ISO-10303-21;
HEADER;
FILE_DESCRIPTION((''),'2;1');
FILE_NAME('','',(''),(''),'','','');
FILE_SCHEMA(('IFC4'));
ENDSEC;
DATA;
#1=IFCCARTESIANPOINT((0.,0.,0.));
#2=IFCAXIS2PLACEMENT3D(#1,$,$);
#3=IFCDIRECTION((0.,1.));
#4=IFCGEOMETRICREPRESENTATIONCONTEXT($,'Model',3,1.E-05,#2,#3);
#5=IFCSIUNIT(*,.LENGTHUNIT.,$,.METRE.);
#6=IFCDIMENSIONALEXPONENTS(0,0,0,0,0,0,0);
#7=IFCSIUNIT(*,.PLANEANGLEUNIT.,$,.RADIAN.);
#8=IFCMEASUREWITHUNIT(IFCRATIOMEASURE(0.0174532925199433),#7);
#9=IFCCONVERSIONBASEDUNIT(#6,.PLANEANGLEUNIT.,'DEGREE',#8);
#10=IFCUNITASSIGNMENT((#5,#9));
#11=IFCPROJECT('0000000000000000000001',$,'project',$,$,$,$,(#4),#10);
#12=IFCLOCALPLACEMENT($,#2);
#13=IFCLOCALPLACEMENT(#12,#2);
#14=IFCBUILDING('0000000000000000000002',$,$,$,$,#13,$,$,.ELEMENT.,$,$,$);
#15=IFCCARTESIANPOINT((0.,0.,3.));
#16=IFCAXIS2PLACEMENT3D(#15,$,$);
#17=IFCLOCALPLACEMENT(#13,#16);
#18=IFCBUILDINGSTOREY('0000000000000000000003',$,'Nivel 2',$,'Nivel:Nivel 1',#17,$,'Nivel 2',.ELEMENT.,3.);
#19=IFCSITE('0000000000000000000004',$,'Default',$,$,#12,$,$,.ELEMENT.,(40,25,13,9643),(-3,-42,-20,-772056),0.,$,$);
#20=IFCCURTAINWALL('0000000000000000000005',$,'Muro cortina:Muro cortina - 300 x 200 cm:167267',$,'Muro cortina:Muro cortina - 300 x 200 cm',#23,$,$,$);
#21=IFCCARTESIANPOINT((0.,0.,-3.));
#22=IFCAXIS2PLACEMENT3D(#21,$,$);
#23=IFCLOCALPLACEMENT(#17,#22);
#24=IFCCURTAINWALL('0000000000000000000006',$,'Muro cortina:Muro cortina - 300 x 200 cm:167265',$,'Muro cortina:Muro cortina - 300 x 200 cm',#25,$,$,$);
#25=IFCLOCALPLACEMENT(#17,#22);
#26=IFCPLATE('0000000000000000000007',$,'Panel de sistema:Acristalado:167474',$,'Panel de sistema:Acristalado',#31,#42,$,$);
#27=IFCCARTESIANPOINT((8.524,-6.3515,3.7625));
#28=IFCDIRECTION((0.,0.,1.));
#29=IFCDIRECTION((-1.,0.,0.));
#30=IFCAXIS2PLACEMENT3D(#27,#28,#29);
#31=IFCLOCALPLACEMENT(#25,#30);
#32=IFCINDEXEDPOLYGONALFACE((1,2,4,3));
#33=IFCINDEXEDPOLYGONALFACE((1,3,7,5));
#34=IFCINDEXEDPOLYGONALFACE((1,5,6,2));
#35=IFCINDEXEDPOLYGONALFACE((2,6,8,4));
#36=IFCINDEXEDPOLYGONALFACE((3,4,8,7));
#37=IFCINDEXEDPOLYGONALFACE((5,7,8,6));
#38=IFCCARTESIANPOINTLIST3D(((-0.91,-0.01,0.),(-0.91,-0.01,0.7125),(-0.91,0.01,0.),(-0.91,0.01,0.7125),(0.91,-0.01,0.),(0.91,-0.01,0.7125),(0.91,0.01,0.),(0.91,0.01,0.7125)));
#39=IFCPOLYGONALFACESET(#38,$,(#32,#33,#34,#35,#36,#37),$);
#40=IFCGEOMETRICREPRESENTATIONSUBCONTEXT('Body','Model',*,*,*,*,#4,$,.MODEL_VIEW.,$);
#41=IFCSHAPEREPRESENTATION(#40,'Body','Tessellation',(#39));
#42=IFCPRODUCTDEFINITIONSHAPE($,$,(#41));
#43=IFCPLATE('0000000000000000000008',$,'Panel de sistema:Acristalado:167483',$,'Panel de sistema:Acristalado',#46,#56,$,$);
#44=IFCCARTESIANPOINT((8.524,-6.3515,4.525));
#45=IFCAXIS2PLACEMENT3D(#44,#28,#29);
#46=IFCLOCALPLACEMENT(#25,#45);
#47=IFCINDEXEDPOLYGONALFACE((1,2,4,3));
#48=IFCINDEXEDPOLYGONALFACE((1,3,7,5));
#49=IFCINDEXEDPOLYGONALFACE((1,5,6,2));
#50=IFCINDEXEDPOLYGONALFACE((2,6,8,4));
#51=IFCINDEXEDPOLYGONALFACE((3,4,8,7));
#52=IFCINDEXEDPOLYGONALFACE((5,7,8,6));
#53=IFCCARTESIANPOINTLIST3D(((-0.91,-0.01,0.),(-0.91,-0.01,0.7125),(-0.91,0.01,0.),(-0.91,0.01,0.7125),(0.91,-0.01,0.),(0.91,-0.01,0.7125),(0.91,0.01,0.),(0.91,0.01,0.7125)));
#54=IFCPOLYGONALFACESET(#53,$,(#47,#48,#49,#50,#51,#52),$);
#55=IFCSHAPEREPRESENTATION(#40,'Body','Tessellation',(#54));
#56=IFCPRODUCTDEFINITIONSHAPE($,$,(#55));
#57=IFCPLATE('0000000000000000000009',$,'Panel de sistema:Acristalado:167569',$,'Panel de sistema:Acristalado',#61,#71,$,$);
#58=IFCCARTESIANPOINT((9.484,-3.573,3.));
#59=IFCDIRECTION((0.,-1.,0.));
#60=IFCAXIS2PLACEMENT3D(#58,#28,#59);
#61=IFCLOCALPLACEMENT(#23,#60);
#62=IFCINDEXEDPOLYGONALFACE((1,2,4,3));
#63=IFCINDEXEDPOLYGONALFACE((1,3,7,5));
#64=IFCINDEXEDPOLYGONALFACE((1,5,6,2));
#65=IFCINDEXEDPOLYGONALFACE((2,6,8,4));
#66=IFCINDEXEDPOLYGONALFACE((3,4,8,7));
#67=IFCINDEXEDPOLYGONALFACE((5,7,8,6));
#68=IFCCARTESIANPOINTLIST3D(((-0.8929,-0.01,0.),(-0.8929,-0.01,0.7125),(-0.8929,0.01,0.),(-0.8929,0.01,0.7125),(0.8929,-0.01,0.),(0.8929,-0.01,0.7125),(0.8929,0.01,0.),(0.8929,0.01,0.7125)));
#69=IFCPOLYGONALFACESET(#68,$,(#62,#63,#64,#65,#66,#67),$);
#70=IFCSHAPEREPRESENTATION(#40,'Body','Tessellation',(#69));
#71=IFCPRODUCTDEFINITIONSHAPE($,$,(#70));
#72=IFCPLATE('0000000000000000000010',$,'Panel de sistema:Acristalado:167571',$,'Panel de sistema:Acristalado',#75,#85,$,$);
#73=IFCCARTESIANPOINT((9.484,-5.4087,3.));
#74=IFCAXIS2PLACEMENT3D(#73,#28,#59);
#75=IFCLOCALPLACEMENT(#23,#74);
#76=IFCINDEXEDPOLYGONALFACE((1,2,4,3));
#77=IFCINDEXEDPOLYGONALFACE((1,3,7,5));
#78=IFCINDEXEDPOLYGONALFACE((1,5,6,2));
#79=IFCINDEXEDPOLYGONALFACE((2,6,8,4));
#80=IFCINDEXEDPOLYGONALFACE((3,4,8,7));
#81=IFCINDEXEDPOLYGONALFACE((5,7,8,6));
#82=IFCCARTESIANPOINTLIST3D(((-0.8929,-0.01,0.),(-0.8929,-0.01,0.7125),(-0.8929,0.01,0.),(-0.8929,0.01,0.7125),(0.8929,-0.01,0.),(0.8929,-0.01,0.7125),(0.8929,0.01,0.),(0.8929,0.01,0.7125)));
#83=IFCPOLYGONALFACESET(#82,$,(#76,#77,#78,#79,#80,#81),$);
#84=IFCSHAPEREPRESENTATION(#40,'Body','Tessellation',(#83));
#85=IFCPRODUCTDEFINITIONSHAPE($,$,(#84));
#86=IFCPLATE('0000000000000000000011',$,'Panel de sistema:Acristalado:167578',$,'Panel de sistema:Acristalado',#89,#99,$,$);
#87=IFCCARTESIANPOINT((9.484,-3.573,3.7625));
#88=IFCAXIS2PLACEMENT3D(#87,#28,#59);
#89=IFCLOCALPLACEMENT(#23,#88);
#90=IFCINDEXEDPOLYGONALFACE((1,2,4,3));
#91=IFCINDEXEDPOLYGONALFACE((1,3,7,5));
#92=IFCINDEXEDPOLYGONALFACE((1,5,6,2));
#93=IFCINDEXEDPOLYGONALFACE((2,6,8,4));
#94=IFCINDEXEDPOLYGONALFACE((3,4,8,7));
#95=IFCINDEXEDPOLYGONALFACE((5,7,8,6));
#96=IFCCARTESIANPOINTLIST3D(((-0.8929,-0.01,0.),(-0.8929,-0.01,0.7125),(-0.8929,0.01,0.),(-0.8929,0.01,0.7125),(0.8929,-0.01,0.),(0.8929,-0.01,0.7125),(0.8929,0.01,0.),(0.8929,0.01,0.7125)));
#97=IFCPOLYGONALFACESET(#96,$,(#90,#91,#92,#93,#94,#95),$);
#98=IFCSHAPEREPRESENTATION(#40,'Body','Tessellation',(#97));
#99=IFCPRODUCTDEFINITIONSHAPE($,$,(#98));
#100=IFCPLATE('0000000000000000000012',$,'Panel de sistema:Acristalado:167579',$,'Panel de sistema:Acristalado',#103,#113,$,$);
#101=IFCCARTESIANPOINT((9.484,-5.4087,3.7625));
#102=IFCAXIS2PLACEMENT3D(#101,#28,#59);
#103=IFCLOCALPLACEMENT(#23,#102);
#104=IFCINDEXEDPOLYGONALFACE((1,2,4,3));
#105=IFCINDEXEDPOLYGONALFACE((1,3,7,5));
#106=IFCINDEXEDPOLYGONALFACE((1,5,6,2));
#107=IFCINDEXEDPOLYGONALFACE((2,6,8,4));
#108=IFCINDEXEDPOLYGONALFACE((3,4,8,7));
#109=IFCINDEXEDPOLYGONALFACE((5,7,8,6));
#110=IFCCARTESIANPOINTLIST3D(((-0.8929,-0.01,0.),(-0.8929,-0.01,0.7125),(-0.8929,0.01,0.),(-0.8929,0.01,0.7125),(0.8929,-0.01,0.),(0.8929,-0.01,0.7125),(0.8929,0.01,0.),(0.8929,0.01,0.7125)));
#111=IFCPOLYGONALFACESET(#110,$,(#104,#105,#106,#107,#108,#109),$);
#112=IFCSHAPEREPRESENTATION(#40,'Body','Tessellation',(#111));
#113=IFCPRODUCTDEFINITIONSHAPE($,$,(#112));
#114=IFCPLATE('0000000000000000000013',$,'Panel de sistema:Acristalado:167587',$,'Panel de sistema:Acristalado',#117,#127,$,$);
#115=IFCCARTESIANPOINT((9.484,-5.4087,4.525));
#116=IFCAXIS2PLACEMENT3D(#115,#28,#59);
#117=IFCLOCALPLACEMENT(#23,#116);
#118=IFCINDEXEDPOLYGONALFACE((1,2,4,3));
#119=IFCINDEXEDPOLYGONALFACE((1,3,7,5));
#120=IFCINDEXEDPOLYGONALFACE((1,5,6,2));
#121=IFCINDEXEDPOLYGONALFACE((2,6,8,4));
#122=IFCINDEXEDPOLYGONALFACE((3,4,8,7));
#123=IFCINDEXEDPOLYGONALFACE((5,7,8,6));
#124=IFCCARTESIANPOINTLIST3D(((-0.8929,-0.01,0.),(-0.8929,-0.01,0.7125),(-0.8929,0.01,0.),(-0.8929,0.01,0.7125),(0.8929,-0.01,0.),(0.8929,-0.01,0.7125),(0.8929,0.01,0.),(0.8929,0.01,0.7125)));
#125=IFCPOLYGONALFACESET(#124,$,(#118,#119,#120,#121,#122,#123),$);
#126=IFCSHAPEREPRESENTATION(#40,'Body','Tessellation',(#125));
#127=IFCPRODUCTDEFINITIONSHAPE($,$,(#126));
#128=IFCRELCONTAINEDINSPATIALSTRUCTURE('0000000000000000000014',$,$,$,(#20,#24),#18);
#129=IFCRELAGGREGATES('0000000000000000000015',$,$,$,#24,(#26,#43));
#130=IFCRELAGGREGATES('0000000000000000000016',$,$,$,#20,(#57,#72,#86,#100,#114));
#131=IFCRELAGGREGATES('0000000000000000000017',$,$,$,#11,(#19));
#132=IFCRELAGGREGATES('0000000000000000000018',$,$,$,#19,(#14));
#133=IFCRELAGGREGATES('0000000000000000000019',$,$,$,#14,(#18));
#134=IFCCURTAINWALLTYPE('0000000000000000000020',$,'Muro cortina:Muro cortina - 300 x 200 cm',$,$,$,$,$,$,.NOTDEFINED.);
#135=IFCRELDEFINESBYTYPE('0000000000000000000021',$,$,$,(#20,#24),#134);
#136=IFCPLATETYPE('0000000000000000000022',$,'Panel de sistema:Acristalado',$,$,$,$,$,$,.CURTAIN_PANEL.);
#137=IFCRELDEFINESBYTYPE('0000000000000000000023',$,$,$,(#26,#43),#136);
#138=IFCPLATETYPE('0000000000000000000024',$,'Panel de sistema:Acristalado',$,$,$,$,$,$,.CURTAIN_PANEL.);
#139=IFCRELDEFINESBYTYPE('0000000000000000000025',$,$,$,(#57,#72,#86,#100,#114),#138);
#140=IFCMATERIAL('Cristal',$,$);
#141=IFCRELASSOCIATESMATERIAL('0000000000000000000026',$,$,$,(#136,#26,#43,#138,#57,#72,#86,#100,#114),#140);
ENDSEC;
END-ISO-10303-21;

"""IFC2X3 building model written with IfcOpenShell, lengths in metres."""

from ifc_helpers import new_model, entity, si_unit, converted_unit, direction, frame, origin, origin_2d_with_axis, place, context, subcontext, project, spatial, rectangle, extrude, source, transform, mapped, material, type_object, type_shapes, element, aggregate, save


model = new_model("IFC2X3")

# Units and contexts
model_context = context("Model", 3, precision=1e-05, world=origin(), true_north=direction((0.0, 1.0)))
body_context = subcontext(model_context, "Body", "Model", "MODEL_VIEW")
ifc_project = project(units=[si_unit("LENGTHUNIT", "METRE"), converted_unit("PLANEANGLEUNIT", "DEGREE", entity("IfcRatioMeasure", 0.0174532925199433), si_unit("PLANEANGLEUNIT", "RADIAN"), dimensions=[0, 0, 0, 0, 0, 0, 0])], contexts=[model_context])

# Site, building, storey
site_placement = place(None, origin())
site = spatial("IfcSite", under=ifc_project, at=site_placement, Name="Default", CompositionType="ELEMENT", RefLatitude=(40, 25, 13, 9643), RefLongitude=(-3, -42, -20, -772056), RefElevation=0.0)
building_placement = place(site_placement, origin())
building = spatial("IfcBuilding", under=site, at=building_placement, CompositionType="ELEMENT")
storey_placement = place(building_placement, frame((0.0, 0.0, 3.0)))
storey = spatial("IfcBuildingStorey", under=building, at=storey_placement, Name="Nivel 2", ObjectType="Nivel:Nivel 1", LongName="Nivel 2", CompositionType="ELEMENT", Elevation=3.0)

# Curtain walls
curtain_wall_type = type_object("IfcCurtainWallType", Name="Muro cortina:Muro cortina - 300 x 200 cm", PredefinedType="NOTDEFINED")
curtain_wall_1_placement = place(storey_placement, frame((0.0, 0.0, -3.0)))
curtain_wall_1 = element("IfcCurtainWall", 1, at=curtain_wall_1_placement, inside=storey, type_object=curtain_wall_type, Name="Muro cortina:Muro cortina - 300 x 200 cm:167267", ObjectType="Muro cortina:Muro cortina - 300 x 200 cm")
curtain_wall_2_placement = place(storey_placement, frame((0.0, 0.0, -3.0)))
curtain_wall_2 = element("IfcCurtainWall", 2, at=curtain_wall_2_placement, inside=storey, type_object=curtain_wall_type, Name="Muro cortina:Muro cortina - 300 x 200 cm:167265", ObjectType="Muro cortina:Muro cortina - 300 x 200 cm")

# Plates
ifc_material_1 = material(Name="Cristal")
plate_type_1 = type_object("IfcPlateType", Name="Panel de sistema:Acristalado", PredefinedType="CURTAIN_PANEL", material=ifc_material_1)
shared_shape_1 = source(origin(), body_context, "Body", "SweptSolid", [
    extrude(rectangle(XDim=0.02, YDim=1.82, at=origin_2d_with_axis()), frame((0.0, 0.0, 0.0), z_axis=(0.0, 0.0, 1.0), x_axis=(0.0, 1.0, 0.0)), (0.0, 0.0, 1.0), 0.7125),
])
type_shapes(plate_type_1, [shared_shape_1])
plate_1_placement = place(curtain_wall_2_placement, frame((8.524, -6.3515, 3.7625), z_axis=(0.0, 0.0, 1.0), x_axis=(-1.0, 0.0, 0.0)))
plate_1 = element("IfcPlate", 3, at=plate_1_placement, type_object=plate_type_1, material=ifc_material_1, Name="Panel de sistema:Acristalado:167474", ObjectType="Panel de sistema:Acristalado", context=body_context, shape_type="MappedRepresentation", body=[
    mapped(shared_shape_1, transform((0.0, 0.0, 0.0), scale=1.0)),
])
plate_2_placement = place(curtain_wall_2_placement, frame((8.524, -6.3515, 4.525), z_axis=(0.0, 0.0, 1.0), x_axis=(-1.0, 0.0, 0.0)))
plate_2 = element("IfcPlate", 4, at=plate_2_placement, type_object=plate_type_1, material=ifc_material_1, Name="Panel de sistema:Acristalado:167483", ObjectType="Panel de sistema:Acristalado", context=body_context, shape_type="MappedRepresentation", body=[
    mapped(shared_shape_1, transform((0.0, 0.0, 0.0), scale=1.0)),
])
aggregate(curtain_wall_2, [plate_1, plate_2])
plate_type_2 = type_object("IfcPlateType", Name="Panel de sistema:Acristalado", PredefinedType="CURTAIN_PANEL", material=ifc_material_1)
shared_shape_2 = source(origin(), body_context, "Body", "SweptSolid", [
    extrude(rectangle(XDim=0.02, YDim=1.7857, at=origin_2d_with_axis()), frame((0.0, 0.0, 0.0), z_axis=(0.0, 0.0, 1.0), x_axis=(0.0, 1.0, 0.0)), (0.0, 0.0, 1.0), 0.7125),
])
type_shapes(plate_type_2, [shared_shape_2])
plate_3_placement = place(curtain_wall_1_placement, frame((9.484, -3.573, 3.0), z_axis=(0.0, 0.0, 1.0), x_axis=(0.0, -1.0, 0.0)))
plate_3 = element("IfcPlate", 5, at=plate_3_placement, type_object=plate_type_2, material=ifc_material_1, Name="Panel de sistema:Acristalado:167569", ObjectType="Panel de sistema:Acristalado", context=body_context, shape_type="MappedRepresentation", body=[
    mapped(shared_shape_2, transform((0.0, 0.0, 0.0), scale=1.0)),
])
plate_4_placement = place(curtain_wall_1_placement, frame((9.484, -5.4087, 3.0), z_axis=(0.0, 0.0, 1.0), x_axis=(0.0, -1.0, 0.0)))
plate_4 = element("IfcPlate", 6, at=plate_4_placement, type_object=plate_type_2, material=ifc_material_1, Name="Panel de sistema:Acristalado:167571", ObjectType="Panel de sistema:Acristalado", context=body_context, shape_type="MappedRepresentation", body=[
    mapped(shared_shape_2, transform((0.0, 0.0, 0.0), scale=1.0)),
])
plate_5_placement = place(curtain_wall_1_placement, frame((9.484, -3.573, 3.7625), z_axis=(0.0, 0.0, 1.0), x_axis=(0.0, -1.0, 0.0)))
plate_5 = element("IfcPlate", 7, at=plate_5_placement, type_object=plate_type_2, material=ifc_material_1, Name="Panel de sistema:Acristalado:167578", ObjectType="Panel de sistema:Acristalado", context=body_context, shape_type="MappedRepresentation", body=[
    mapped(shared_shape_2, transform((0.0, 0.0, 0.0), scale=1.0)),
])
plate_6_placement = place(curtain_wall_1_placement, frame((9.484, -5.4087, 3.7625), z_axis=(0.0, 0.0, 1.0), x_axis=(0.0, -1.0, 0.0)))
plate_6 = element("IfcPlate", 8, at=plate_6_placement, type_object=plate_type_2, material=ifc_material_1, Name="Panel de sistema:Acristalado:167579", ObjectType="Panel de sistema:Acristalado", context=body_context, shape_type="MappedRepresentation", body=[
    mapped(shared_shape_2, transform((0.0, 0.0, 0.0), scale=1.0)),
])
plate_7_placement = place(curtain_wall_1_placement, frame((9.484, -5.4087, 4.525), z_axis=(0.0, 0.0, 1.0), x_axis=(0.0, -1.0, 0.0)))
plate_7 = element("IfcPlate", 9, at=plate_7_placement, type_object=plate_type_2, material=ifc_material_1, Name="Panel de sistema:Acristalado:167587", ObjectType="Panel de sistema:Acristalado", context=body_context, shape_type="MappedRepresentation", body=[
    mapped(shared_shape_2, transform((0.0, 0.0, 0.0), scale=1.0)),
])
aggregate(curtain_wall_1, [plate_3, plate_4, plate_5, plate_6, plate_7])

save(model, "model.ifc")
